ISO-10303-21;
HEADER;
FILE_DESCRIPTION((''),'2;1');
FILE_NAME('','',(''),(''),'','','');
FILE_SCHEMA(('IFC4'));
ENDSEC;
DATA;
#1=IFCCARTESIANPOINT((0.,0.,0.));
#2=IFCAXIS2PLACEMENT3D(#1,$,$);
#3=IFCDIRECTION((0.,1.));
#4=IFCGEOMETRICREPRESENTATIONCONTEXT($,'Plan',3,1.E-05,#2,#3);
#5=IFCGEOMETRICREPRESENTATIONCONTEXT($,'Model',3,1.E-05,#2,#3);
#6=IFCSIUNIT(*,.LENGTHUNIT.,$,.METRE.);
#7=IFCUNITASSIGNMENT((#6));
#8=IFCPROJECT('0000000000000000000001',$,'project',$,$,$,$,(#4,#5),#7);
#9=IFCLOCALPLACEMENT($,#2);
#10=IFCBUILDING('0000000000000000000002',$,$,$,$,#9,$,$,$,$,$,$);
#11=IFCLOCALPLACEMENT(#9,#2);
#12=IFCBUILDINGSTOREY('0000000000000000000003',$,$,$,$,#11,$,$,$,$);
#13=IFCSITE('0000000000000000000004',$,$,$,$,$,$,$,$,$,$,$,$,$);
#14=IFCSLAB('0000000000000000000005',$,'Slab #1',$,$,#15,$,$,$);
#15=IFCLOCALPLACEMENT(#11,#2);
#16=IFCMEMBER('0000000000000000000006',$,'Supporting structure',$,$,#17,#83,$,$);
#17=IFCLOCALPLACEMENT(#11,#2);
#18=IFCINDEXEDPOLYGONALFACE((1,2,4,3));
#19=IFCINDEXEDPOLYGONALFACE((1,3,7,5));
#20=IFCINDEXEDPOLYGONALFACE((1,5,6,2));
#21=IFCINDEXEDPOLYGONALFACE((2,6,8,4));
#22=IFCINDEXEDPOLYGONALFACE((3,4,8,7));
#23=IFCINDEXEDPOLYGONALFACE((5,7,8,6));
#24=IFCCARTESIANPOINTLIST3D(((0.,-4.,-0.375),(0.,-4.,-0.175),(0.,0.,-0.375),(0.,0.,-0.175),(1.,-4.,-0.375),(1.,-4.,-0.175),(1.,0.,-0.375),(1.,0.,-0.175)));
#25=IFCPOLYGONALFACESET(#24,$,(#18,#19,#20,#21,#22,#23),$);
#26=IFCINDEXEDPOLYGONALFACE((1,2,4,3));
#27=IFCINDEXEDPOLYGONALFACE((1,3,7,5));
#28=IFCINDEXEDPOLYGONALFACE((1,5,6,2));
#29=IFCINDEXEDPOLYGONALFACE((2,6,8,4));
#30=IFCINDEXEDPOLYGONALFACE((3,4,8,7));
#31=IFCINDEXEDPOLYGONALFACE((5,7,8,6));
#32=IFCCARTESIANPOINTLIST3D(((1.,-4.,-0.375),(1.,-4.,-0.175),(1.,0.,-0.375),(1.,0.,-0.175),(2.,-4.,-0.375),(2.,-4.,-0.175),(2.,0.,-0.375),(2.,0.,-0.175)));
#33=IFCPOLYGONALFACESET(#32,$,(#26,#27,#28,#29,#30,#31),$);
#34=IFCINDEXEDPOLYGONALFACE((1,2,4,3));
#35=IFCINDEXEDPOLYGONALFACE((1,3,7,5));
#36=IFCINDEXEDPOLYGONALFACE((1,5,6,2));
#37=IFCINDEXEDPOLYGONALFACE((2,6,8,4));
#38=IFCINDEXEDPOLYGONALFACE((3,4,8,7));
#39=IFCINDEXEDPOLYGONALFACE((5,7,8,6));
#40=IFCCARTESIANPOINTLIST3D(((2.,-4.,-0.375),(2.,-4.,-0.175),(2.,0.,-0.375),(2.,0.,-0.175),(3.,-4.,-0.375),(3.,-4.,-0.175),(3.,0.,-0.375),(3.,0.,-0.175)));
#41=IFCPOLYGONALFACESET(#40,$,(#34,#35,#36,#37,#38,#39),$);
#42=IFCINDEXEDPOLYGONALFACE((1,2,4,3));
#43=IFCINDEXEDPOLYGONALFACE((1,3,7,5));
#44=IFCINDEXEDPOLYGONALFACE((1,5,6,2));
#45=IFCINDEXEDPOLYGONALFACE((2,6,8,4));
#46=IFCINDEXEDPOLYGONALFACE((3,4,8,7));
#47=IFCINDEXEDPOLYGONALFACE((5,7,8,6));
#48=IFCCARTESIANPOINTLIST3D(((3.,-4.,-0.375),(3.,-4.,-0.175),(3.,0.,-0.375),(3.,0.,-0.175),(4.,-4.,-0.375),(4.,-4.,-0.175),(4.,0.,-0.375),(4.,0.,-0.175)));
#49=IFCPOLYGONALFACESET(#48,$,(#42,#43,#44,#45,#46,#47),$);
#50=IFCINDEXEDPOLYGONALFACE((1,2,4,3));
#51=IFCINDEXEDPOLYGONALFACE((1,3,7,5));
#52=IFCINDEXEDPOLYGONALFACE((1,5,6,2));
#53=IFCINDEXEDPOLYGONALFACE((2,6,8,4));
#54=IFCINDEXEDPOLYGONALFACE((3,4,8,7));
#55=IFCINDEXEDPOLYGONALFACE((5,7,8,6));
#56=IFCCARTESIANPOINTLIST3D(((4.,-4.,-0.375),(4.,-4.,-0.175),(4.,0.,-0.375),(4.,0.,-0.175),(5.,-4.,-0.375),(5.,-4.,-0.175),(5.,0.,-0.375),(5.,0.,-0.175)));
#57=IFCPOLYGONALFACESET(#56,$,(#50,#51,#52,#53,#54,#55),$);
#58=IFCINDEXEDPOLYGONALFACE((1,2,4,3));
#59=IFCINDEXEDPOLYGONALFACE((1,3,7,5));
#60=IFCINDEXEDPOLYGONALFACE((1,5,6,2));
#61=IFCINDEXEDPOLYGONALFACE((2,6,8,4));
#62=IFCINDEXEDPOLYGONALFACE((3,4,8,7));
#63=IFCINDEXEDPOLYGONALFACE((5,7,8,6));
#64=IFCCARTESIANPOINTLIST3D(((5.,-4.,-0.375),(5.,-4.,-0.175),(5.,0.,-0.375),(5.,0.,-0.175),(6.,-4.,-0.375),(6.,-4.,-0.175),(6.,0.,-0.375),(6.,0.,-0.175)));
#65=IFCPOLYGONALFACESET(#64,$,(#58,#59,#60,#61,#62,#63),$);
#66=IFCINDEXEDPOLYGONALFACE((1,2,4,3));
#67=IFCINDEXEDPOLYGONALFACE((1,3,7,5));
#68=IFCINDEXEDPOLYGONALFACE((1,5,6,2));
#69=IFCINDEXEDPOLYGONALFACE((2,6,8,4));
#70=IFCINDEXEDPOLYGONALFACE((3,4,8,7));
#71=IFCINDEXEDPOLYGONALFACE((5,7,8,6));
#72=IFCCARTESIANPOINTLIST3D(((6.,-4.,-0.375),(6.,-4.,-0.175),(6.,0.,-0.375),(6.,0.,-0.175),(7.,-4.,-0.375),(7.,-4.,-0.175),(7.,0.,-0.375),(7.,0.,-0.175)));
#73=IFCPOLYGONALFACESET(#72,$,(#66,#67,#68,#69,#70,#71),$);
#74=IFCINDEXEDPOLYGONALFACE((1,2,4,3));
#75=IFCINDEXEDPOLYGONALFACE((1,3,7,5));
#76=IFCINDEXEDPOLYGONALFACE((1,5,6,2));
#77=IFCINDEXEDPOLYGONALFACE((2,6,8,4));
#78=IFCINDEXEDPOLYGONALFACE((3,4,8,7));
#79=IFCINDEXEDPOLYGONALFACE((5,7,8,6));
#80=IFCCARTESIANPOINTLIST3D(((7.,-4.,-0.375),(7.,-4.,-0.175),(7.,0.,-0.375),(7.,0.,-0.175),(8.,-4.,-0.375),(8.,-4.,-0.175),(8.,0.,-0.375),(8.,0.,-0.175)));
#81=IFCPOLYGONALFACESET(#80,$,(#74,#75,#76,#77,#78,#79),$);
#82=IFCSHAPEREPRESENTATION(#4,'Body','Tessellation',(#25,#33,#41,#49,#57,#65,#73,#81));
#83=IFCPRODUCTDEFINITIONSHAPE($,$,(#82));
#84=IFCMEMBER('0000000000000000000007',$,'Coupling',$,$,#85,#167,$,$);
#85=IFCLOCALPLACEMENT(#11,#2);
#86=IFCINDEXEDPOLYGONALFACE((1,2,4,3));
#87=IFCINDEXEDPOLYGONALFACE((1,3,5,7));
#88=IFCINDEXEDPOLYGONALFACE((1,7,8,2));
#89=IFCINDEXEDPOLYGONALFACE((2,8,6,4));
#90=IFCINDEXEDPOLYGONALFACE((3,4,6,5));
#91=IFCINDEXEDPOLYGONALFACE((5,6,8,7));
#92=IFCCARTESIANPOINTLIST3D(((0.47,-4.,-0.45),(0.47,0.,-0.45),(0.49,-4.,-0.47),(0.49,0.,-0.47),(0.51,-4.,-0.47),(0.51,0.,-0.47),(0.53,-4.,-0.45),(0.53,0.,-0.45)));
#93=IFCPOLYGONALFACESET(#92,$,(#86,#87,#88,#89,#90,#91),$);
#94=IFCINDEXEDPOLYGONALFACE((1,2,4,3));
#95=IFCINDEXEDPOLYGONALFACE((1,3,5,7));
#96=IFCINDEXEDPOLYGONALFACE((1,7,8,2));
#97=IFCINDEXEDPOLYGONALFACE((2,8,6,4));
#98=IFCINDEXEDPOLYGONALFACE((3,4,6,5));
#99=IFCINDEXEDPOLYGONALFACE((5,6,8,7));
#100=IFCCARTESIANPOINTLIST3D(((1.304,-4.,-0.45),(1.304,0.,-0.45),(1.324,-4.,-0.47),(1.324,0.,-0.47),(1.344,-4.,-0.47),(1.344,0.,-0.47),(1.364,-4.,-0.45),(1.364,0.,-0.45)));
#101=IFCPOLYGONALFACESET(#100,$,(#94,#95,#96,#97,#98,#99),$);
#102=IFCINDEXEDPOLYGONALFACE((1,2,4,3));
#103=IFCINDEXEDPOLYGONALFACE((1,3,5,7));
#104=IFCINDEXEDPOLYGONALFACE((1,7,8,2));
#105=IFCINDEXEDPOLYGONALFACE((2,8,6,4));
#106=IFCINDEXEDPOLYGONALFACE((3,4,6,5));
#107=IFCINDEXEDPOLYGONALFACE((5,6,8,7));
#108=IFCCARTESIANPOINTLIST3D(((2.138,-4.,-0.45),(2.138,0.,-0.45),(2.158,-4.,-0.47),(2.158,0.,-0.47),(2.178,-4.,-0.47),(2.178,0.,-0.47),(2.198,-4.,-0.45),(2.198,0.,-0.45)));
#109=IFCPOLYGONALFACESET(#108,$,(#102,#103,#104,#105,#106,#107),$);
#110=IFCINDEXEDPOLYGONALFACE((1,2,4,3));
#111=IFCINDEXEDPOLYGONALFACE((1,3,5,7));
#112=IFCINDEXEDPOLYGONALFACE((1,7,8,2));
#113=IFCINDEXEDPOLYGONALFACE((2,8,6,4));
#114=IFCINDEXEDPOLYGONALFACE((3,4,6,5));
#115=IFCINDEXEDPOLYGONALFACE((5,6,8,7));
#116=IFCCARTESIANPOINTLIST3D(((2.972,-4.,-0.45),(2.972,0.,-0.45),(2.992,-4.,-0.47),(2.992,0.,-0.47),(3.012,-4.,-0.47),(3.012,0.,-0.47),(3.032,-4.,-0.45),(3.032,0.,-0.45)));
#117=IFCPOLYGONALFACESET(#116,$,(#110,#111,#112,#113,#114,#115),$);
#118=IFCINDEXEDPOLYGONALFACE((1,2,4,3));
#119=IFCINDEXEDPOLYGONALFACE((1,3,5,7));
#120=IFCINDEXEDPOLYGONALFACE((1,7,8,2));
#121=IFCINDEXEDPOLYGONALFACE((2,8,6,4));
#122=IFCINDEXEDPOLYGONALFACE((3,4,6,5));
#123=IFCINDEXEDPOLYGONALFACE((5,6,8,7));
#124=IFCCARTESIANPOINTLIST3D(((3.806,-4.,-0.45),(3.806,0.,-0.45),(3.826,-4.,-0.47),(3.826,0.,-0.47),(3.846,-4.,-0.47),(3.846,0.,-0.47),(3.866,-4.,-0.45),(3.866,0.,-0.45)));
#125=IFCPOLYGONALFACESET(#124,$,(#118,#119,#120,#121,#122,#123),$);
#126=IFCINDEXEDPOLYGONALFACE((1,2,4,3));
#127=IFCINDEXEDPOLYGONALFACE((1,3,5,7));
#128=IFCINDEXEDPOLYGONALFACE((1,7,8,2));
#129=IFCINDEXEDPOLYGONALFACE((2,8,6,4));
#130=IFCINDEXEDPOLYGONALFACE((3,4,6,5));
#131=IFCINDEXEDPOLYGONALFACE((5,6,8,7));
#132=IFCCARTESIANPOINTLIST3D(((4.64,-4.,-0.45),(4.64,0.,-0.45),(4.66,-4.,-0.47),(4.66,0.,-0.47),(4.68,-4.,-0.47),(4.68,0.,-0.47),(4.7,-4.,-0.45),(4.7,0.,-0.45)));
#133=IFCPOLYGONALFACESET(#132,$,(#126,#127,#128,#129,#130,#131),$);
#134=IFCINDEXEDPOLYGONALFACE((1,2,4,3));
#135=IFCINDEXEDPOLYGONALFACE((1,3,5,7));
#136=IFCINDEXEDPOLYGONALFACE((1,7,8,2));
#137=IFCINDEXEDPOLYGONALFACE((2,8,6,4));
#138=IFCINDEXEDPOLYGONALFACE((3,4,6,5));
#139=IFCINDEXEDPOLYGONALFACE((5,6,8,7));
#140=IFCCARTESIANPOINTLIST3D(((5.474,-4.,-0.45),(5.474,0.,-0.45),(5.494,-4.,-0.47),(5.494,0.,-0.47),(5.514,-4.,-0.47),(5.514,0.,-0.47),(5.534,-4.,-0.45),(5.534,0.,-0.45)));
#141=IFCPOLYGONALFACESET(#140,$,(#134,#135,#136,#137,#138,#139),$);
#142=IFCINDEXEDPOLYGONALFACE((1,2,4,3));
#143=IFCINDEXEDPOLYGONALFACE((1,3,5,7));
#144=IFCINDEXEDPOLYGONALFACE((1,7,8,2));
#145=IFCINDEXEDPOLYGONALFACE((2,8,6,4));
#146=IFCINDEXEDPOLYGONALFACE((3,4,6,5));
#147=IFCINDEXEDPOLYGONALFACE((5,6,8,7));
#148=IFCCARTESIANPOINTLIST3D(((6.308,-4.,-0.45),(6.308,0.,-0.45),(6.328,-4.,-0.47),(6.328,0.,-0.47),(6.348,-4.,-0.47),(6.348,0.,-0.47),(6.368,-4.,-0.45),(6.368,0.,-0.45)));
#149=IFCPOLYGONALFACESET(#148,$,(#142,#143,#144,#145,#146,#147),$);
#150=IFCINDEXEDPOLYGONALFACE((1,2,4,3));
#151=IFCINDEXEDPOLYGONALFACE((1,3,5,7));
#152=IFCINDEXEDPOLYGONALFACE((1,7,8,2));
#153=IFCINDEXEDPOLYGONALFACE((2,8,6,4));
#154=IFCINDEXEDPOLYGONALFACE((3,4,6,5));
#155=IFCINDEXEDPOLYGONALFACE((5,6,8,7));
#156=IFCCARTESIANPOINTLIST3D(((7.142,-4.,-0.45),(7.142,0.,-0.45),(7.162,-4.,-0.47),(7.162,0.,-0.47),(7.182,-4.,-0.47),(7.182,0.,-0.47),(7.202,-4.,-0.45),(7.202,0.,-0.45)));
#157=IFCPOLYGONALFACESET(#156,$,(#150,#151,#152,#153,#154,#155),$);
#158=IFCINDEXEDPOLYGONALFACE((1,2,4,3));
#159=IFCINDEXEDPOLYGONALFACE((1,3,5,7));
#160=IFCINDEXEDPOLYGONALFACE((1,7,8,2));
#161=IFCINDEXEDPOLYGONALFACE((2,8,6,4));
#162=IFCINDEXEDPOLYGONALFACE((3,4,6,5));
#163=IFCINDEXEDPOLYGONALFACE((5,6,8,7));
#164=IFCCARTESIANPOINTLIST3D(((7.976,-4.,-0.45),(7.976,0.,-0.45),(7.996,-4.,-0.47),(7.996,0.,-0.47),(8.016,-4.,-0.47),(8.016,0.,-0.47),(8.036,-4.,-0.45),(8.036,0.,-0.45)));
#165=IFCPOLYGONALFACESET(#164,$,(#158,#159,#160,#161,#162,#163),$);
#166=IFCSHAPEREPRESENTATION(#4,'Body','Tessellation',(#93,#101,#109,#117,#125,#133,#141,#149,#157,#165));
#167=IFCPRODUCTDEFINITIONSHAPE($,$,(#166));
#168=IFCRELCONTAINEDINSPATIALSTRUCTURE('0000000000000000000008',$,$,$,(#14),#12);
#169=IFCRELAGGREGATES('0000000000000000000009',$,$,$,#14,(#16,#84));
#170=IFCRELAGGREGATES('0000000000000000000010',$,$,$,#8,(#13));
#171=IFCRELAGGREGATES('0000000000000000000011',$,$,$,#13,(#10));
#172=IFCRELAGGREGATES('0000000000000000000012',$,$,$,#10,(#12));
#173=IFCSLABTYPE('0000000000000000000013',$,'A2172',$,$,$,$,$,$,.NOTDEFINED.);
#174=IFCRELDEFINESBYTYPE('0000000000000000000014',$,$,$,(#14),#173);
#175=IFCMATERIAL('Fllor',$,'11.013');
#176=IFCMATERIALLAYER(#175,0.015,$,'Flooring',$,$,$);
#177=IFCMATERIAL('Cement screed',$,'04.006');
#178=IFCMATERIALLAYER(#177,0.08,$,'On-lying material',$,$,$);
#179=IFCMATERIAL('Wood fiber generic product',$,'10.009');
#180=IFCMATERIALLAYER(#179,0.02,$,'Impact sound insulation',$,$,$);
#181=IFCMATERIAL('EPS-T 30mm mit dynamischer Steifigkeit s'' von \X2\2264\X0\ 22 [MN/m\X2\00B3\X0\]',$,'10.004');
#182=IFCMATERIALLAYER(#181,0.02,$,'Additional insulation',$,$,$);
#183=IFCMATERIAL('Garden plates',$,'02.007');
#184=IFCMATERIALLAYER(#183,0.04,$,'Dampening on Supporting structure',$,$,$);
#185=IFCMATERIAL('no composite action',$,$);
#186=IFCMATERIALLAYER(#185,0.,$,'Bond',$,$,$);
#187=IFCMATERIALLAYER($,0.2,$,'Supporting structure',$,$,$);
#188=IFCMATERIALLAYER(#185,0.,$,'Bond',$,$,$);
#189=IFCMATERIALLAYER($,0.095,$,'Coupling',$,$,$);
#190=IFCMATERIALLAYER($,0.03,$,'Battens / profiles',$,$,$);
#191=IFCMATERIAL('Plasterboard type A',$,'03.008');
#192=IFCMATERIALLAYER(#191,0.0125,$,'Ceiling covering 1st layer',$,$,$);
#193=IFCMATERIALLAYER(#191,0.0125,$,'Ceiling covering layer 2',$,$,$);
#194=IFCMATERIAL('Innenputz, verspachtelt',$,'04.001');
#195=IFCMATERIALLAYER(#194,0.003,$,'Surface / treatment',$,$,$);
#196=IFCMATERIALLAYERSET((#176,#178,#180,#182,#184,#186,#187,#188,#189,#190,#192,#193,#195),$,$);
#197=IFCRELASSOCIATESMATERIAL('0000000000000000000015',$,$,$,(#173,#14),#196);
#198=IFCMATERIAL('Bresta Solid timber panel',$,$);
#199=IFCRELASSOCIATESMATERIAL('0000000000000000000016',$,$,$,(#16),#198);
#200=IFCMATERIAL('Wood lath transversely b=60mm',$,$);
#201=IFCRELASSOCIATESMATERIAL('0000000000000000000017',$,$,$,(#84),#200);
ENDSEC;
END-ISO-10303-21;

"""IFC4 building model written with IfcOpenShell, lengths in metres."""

from ifc_helpers import new_model, si_unit, direction, frame, frame_2d, origin, place, context, project, spatial, polyline, rectangle, outline, extrude, material, layer, layer_set, type_object, element, aggregate, save


model = new_model("IFC4")

# Units and contexts
plan_context = context("Plan", 3, precision=1e-05, world=origin(), true_north=direction((0.0, 1.0)))
model_context = context("Model", 3, precision=1e-05, world=origin(), true_north=direction((0.0, 1.0)))
ifc_project = project(units=[si_unit("LENGTHUNIT", "METRE")], contexts=[plan_context, model_context])

# Site, building, storey
site = spatial("IfcSite", under=ifc_project)
building_placement = place(None, origin())
building = spatial("IfcBuilding", under=site, at=building_placement)
storey_placement = place(building_placement, origin())
storey = spatial("IfcBuildingStorey", under=building, at=storey_placement)

# Slab, members
ifc_material_1 = material(Name="Fllor", Category="11.013")
ifc_layer_1 = layer(ifc_material_1, 0.015, Name="Flooring")
ifc_material_2 = material(Name="Cement screed", Category="04.006")
ifc_layer_2 = layer(ifc_material_2, 0.08, Name="On-lying material")
ifc_material_3 = material(Name="Wood fiber generic product", Category="10.009")
ifc_layer_3 = layer(ifc_material_3, 0.02, Name="Impact sound insulation")
ifc_material_4 = material(Name="EPS-T 30mm mit dynamischer Steifigkeit s' von ≤ 22 [MN/m³]", Category="10.004")
ifc_layer_4 = layer(ifc_material_4, 0.02, Name="Additional insulation")
ifc_material_5 = material(Name="Garden plates", Category="02.007")
ifc_layer_5 = layer(ifc_material_5, 0.04, Name="Dampening on Supporting structure")
ifc_material_6 = material(Name="no composite action")
ifc_layer_6 = layer(ifc_material_6, 0.0, Name="Bond")
ifc_layer_7 = layer(None, 0.2, Name="Supporting structure")
ifc_layer_8 = layer(ifc_material_6, 0.0, Name="Bond")
ifc_layer_9 = layer(None, 0.095, Name="Coupling")
ifc_layer_10 = layer(None, 0.03, Name="Battens / profiles")
ifc_material_7 = material(Name="Plasterboard type A", Category="03.008")
ifc_layer_11 = layer(ifc_material_7, 0.0125, Name="Ceiling covering 1st layer")
ifc_layer_12 = layer(ifc_material_7, 0.0125, Name="Ceiling covering layer 2")
ifc_material_8 = material(Name="Innenputz, verspachtelt", Category="04.001")
ifc_layer_13 = layer(ifc_material_8, 0.003, Name="Surface / treatment")
ifc_layer_set = layer_set([ifc_layer_1, ifc_layer_2, ifc_layer_3, ifc_layer_4, ifc_layer_5, ifc_layer_6, ifc_layer_7, ifc_layer_8, ifc_layer_9, ifc_layer_10, ifc_layer_11, ifc_layer_12, ifc_layer_13])
slab_type = type_object("IfcSlabType", Name="A2172", PredefinedType="NOTDEFINED", material=ifc_layer_set)
slab_placement = place(None, frame((0.0, 0.0, 0.0), z_axis=(0.0, 0.0, -1.0), x_axis=(1.0, 0.0, 0.0)))
slab = element("IfcSlab", 1, at=slab_placement, inside=storey, type_object=slab_type, material=ifc_layer_set, Name="Slab #1")
ifc_material_9 = material(Name="Bresta Solid timber panel")
member_1_placement = place(slab_placement, origin())
member_1 = element("IfcMember", 2, at=member_1_placement, material=ifc_material_9, Name="Supporting structure", context=plan_context, shape_type="SweptSolid", body=[
    extrude(rectangle(XDim=1.0, YDim=0.2, at=frame_2d((0.5, 0.1), x_axis=(1.0, 0.0))), frame((0.0, 4.0, 0.175), z_axis=(0.0, -1.0, 0.0), x_axis=(1.0, 0.0, 0.0)), (0.0, 0.0, 1.0), 4.0),
    extrude(rectangle(XDim=1.0, YDim=0.2, at=frame_2d((0.5, 0.1), x_axis=(1.0, 0.0))), frame((1.0, 4.0, 0.175), z_axis=(0.0, -1.0, 0.0), x_axis=(1.0, 0.0, 0.0)), (0.0, 0.0, 1.0), 4.0),
    extrude(rectangle(XDim=1.0, YDim=0.2, at=frame_2d((0.5, 0.1), x_axis=(1.0, 0.0))), frame((2.0, 4.0, 0.175), z_axis=(0.0, -1.0, 0.0), x_axis=(1.0, 0.0, 0.0)), (0.0, 0.0, 1.0), 4.0),
    extrude(rectangle(XDim=1.0, YDim=0.2, at=frame_2d((0.5, 0.1), x_axis=(1.0, 0.0))), frame((3.0, 4.0, 0.175), z_axis=(0.0, -1.0, 0.0), x_axis=(1.0, 0.0, 0.0)), (0.0, 0.0, 1.0), 4.0),
    extrude(rectangle(XDim=1.0, YDim=0.2, at=frame_2d((0.5, 0.1), x_axis=(1.0, 0.0))), frame((4.0, 4.0, 0.175), z_axis=(0.0, -1.0, 0.0), x_axis=(1.0, 0.0, 0.0)), (0.0, 0.0, 1.0), 4.0),
    extrude(rectangle(XDim=1.0, YDim=0.2, at=frame_2d((0.5, 0.1), x_axis=(1.0, 0.0))), frame((5.0, 4.0, 0.175), z_axis=(0.0, -1.0, 0.0), x_axis=(1.0, 0.0, 0.0)), (0.0, 0.0, 1.0), 4.0),
    extrude(rectangle(XDim=1.0, YDim=0.2, at=frame_2d((0.5, 0.1), x_axis=(1.0, 0.0))), frame((6.0, 4.0, 0.175), z_axis=(0.0, -1.0, 0.0), x_axis=(1.0, 0.0, 0.0)), (0.0, 0.0, 1.0), 4.0),
    extrude(rectangle(XDim=1.0, YDim=0.2, at=frame_2d((0.5, 0.1), x_axis=(1.0, 0.0))), frame((7.0, 4.0, 0.175), z_axis=(0.0, -1.0, 0.0), x_axis=(1.0, 0.0, 0.0)), (0.0, 0.0, 1.0), 4.0),
])
ifc_material_10 = material(Name="Wood lath transversely b=60mm")
member_2_placement = place(slab_placement, origin())
member_2 = element("IfcMember", 3, at=member_2_placement, material=ifc_material_10, Name="Coupling", context=plan_context, shape_type="SweptSolid", body=[
    extrude(outline(polyline([(0.0, 0.0), (0.06, 0.0), (0.04, 0.02), (0.02, 0.02), (0.0, 0.0)])), frame((0.47, 4.0, 0.45), z_axis=(0.0, -1.0, 0.0), x_axis=(1.0, 0.0, 0.0)), (0.0, 0.0, 1.0), 4.0),
    extrude(outline(polyline([(0.0, 0.0), (0.06, 0.0), (0.04, 0.02), (0.02, 0.02), (0.0, 0.0)])), frame((1.304, 4.0, 0.45), z_axis=(0.0, -1.0, 0.0), x_axis=(1.0, 0.0, 0.0)), (0.0, 0.0, 1.0), 4.0),
    extrude(outline(polyline([(0.0, 0.0), (0.06, 0.0), (0.04, 0.02), (0.02, 0.02), (0.0, 0.0)])), frame((2.138, 4.0, 0.45), z_axis=(0.0, -1.0, 0.0), x_axis=(1.0, 0.0, 0.0)), (0.0, 0.0, 1.0), 4.0),
    extrude(outline(polyline([(0.0, 0.0), (0.06, 0.0), (0.04, 0.02), (0.02, 0.02), (0.0, 0.0)])), frame((2.972, 4.0, 0.45), z_axis=(0.0, -1.0, 0.0), x_axis=(1.0, 0.0, 0.0)), (0.0, 0.0, 1.0), 4.0),
    extrude(outline(polyline([(0.0, 0.0), (0.06, 0.0), (0.04, 0.02), (0.02, 0.02), (0.0, 0.0)])), frame((3.806, 4.0, 0.45), z_axis=(0.0, -1.0, 0.0), x_axis=(1.0, 0.0, 0.0)), (0.0, 0.0, 1.0), 4.0),
    extrude(outline(polyline([(0.0, 0.0), (0.06, 0.0), (0.04, 0.02), (0.02, 0.02), (0.0, 0.0)])), frame((4.64, 4.0, 0.45), z_axis=(0.0, -1.0, 0.0), x_axis=(1.0, 0.0, 0.0)), (0.0, 0.0, 1.0), 4.0),
    extrude(outline(polyline([(0.0, 0.0), (0.06, 0.0), (0.04, 0.02), (0.02, 0.02), (0.0, 0.0)])), frame((5.474, 4.0, 0.45), z_axis=(0.0, -1.0, 0.0), x_axis=(1.0, 0.0, 0.0)), (0.0, 0.0, 1.0), 4.0),
    extrude(outline(polyline([(0.0, 0.0), (0.06, 0.0), (0.04, 0.02), (0.02, 0.02), (0.0, 0.0)])), frame((6.308, 4.0, 0.45), z_axis=(0.0, -1.0, 0.0), x_axis=(1.0, 0.0, 0.0)), (0.0, 0.0, 1.0), 4.0),
    extrude(outline(polyline([(0.0, 0.0), (0.06, 0.0), (0.04, 0.02), (0.02, 0.02), (0.0, 0.0)])), frame((7.142, 4.0, 0.45), z_axis=(0.0, -1.0, 0.0), x_axis=(1.0, 0.0, 0.0)), (0.0, 0.0, 1.0), 4.0),
    extrude(outline(polyline([(0.0, 0.0), (0.06, 0.0), (0.04, 0.02), (0.02, 0.02), (0.0, 0.0)])), frame((7.976, 4.0, 0.45), z_axis=(0.0, -1.0, 0.0), x_axis=(1.0, 0.0, 0.0)), (0.0, 0.0, 1.0), 4.0),
])
aggregate(slab, [member_1, member_2])

save(model, "model.ifc")
